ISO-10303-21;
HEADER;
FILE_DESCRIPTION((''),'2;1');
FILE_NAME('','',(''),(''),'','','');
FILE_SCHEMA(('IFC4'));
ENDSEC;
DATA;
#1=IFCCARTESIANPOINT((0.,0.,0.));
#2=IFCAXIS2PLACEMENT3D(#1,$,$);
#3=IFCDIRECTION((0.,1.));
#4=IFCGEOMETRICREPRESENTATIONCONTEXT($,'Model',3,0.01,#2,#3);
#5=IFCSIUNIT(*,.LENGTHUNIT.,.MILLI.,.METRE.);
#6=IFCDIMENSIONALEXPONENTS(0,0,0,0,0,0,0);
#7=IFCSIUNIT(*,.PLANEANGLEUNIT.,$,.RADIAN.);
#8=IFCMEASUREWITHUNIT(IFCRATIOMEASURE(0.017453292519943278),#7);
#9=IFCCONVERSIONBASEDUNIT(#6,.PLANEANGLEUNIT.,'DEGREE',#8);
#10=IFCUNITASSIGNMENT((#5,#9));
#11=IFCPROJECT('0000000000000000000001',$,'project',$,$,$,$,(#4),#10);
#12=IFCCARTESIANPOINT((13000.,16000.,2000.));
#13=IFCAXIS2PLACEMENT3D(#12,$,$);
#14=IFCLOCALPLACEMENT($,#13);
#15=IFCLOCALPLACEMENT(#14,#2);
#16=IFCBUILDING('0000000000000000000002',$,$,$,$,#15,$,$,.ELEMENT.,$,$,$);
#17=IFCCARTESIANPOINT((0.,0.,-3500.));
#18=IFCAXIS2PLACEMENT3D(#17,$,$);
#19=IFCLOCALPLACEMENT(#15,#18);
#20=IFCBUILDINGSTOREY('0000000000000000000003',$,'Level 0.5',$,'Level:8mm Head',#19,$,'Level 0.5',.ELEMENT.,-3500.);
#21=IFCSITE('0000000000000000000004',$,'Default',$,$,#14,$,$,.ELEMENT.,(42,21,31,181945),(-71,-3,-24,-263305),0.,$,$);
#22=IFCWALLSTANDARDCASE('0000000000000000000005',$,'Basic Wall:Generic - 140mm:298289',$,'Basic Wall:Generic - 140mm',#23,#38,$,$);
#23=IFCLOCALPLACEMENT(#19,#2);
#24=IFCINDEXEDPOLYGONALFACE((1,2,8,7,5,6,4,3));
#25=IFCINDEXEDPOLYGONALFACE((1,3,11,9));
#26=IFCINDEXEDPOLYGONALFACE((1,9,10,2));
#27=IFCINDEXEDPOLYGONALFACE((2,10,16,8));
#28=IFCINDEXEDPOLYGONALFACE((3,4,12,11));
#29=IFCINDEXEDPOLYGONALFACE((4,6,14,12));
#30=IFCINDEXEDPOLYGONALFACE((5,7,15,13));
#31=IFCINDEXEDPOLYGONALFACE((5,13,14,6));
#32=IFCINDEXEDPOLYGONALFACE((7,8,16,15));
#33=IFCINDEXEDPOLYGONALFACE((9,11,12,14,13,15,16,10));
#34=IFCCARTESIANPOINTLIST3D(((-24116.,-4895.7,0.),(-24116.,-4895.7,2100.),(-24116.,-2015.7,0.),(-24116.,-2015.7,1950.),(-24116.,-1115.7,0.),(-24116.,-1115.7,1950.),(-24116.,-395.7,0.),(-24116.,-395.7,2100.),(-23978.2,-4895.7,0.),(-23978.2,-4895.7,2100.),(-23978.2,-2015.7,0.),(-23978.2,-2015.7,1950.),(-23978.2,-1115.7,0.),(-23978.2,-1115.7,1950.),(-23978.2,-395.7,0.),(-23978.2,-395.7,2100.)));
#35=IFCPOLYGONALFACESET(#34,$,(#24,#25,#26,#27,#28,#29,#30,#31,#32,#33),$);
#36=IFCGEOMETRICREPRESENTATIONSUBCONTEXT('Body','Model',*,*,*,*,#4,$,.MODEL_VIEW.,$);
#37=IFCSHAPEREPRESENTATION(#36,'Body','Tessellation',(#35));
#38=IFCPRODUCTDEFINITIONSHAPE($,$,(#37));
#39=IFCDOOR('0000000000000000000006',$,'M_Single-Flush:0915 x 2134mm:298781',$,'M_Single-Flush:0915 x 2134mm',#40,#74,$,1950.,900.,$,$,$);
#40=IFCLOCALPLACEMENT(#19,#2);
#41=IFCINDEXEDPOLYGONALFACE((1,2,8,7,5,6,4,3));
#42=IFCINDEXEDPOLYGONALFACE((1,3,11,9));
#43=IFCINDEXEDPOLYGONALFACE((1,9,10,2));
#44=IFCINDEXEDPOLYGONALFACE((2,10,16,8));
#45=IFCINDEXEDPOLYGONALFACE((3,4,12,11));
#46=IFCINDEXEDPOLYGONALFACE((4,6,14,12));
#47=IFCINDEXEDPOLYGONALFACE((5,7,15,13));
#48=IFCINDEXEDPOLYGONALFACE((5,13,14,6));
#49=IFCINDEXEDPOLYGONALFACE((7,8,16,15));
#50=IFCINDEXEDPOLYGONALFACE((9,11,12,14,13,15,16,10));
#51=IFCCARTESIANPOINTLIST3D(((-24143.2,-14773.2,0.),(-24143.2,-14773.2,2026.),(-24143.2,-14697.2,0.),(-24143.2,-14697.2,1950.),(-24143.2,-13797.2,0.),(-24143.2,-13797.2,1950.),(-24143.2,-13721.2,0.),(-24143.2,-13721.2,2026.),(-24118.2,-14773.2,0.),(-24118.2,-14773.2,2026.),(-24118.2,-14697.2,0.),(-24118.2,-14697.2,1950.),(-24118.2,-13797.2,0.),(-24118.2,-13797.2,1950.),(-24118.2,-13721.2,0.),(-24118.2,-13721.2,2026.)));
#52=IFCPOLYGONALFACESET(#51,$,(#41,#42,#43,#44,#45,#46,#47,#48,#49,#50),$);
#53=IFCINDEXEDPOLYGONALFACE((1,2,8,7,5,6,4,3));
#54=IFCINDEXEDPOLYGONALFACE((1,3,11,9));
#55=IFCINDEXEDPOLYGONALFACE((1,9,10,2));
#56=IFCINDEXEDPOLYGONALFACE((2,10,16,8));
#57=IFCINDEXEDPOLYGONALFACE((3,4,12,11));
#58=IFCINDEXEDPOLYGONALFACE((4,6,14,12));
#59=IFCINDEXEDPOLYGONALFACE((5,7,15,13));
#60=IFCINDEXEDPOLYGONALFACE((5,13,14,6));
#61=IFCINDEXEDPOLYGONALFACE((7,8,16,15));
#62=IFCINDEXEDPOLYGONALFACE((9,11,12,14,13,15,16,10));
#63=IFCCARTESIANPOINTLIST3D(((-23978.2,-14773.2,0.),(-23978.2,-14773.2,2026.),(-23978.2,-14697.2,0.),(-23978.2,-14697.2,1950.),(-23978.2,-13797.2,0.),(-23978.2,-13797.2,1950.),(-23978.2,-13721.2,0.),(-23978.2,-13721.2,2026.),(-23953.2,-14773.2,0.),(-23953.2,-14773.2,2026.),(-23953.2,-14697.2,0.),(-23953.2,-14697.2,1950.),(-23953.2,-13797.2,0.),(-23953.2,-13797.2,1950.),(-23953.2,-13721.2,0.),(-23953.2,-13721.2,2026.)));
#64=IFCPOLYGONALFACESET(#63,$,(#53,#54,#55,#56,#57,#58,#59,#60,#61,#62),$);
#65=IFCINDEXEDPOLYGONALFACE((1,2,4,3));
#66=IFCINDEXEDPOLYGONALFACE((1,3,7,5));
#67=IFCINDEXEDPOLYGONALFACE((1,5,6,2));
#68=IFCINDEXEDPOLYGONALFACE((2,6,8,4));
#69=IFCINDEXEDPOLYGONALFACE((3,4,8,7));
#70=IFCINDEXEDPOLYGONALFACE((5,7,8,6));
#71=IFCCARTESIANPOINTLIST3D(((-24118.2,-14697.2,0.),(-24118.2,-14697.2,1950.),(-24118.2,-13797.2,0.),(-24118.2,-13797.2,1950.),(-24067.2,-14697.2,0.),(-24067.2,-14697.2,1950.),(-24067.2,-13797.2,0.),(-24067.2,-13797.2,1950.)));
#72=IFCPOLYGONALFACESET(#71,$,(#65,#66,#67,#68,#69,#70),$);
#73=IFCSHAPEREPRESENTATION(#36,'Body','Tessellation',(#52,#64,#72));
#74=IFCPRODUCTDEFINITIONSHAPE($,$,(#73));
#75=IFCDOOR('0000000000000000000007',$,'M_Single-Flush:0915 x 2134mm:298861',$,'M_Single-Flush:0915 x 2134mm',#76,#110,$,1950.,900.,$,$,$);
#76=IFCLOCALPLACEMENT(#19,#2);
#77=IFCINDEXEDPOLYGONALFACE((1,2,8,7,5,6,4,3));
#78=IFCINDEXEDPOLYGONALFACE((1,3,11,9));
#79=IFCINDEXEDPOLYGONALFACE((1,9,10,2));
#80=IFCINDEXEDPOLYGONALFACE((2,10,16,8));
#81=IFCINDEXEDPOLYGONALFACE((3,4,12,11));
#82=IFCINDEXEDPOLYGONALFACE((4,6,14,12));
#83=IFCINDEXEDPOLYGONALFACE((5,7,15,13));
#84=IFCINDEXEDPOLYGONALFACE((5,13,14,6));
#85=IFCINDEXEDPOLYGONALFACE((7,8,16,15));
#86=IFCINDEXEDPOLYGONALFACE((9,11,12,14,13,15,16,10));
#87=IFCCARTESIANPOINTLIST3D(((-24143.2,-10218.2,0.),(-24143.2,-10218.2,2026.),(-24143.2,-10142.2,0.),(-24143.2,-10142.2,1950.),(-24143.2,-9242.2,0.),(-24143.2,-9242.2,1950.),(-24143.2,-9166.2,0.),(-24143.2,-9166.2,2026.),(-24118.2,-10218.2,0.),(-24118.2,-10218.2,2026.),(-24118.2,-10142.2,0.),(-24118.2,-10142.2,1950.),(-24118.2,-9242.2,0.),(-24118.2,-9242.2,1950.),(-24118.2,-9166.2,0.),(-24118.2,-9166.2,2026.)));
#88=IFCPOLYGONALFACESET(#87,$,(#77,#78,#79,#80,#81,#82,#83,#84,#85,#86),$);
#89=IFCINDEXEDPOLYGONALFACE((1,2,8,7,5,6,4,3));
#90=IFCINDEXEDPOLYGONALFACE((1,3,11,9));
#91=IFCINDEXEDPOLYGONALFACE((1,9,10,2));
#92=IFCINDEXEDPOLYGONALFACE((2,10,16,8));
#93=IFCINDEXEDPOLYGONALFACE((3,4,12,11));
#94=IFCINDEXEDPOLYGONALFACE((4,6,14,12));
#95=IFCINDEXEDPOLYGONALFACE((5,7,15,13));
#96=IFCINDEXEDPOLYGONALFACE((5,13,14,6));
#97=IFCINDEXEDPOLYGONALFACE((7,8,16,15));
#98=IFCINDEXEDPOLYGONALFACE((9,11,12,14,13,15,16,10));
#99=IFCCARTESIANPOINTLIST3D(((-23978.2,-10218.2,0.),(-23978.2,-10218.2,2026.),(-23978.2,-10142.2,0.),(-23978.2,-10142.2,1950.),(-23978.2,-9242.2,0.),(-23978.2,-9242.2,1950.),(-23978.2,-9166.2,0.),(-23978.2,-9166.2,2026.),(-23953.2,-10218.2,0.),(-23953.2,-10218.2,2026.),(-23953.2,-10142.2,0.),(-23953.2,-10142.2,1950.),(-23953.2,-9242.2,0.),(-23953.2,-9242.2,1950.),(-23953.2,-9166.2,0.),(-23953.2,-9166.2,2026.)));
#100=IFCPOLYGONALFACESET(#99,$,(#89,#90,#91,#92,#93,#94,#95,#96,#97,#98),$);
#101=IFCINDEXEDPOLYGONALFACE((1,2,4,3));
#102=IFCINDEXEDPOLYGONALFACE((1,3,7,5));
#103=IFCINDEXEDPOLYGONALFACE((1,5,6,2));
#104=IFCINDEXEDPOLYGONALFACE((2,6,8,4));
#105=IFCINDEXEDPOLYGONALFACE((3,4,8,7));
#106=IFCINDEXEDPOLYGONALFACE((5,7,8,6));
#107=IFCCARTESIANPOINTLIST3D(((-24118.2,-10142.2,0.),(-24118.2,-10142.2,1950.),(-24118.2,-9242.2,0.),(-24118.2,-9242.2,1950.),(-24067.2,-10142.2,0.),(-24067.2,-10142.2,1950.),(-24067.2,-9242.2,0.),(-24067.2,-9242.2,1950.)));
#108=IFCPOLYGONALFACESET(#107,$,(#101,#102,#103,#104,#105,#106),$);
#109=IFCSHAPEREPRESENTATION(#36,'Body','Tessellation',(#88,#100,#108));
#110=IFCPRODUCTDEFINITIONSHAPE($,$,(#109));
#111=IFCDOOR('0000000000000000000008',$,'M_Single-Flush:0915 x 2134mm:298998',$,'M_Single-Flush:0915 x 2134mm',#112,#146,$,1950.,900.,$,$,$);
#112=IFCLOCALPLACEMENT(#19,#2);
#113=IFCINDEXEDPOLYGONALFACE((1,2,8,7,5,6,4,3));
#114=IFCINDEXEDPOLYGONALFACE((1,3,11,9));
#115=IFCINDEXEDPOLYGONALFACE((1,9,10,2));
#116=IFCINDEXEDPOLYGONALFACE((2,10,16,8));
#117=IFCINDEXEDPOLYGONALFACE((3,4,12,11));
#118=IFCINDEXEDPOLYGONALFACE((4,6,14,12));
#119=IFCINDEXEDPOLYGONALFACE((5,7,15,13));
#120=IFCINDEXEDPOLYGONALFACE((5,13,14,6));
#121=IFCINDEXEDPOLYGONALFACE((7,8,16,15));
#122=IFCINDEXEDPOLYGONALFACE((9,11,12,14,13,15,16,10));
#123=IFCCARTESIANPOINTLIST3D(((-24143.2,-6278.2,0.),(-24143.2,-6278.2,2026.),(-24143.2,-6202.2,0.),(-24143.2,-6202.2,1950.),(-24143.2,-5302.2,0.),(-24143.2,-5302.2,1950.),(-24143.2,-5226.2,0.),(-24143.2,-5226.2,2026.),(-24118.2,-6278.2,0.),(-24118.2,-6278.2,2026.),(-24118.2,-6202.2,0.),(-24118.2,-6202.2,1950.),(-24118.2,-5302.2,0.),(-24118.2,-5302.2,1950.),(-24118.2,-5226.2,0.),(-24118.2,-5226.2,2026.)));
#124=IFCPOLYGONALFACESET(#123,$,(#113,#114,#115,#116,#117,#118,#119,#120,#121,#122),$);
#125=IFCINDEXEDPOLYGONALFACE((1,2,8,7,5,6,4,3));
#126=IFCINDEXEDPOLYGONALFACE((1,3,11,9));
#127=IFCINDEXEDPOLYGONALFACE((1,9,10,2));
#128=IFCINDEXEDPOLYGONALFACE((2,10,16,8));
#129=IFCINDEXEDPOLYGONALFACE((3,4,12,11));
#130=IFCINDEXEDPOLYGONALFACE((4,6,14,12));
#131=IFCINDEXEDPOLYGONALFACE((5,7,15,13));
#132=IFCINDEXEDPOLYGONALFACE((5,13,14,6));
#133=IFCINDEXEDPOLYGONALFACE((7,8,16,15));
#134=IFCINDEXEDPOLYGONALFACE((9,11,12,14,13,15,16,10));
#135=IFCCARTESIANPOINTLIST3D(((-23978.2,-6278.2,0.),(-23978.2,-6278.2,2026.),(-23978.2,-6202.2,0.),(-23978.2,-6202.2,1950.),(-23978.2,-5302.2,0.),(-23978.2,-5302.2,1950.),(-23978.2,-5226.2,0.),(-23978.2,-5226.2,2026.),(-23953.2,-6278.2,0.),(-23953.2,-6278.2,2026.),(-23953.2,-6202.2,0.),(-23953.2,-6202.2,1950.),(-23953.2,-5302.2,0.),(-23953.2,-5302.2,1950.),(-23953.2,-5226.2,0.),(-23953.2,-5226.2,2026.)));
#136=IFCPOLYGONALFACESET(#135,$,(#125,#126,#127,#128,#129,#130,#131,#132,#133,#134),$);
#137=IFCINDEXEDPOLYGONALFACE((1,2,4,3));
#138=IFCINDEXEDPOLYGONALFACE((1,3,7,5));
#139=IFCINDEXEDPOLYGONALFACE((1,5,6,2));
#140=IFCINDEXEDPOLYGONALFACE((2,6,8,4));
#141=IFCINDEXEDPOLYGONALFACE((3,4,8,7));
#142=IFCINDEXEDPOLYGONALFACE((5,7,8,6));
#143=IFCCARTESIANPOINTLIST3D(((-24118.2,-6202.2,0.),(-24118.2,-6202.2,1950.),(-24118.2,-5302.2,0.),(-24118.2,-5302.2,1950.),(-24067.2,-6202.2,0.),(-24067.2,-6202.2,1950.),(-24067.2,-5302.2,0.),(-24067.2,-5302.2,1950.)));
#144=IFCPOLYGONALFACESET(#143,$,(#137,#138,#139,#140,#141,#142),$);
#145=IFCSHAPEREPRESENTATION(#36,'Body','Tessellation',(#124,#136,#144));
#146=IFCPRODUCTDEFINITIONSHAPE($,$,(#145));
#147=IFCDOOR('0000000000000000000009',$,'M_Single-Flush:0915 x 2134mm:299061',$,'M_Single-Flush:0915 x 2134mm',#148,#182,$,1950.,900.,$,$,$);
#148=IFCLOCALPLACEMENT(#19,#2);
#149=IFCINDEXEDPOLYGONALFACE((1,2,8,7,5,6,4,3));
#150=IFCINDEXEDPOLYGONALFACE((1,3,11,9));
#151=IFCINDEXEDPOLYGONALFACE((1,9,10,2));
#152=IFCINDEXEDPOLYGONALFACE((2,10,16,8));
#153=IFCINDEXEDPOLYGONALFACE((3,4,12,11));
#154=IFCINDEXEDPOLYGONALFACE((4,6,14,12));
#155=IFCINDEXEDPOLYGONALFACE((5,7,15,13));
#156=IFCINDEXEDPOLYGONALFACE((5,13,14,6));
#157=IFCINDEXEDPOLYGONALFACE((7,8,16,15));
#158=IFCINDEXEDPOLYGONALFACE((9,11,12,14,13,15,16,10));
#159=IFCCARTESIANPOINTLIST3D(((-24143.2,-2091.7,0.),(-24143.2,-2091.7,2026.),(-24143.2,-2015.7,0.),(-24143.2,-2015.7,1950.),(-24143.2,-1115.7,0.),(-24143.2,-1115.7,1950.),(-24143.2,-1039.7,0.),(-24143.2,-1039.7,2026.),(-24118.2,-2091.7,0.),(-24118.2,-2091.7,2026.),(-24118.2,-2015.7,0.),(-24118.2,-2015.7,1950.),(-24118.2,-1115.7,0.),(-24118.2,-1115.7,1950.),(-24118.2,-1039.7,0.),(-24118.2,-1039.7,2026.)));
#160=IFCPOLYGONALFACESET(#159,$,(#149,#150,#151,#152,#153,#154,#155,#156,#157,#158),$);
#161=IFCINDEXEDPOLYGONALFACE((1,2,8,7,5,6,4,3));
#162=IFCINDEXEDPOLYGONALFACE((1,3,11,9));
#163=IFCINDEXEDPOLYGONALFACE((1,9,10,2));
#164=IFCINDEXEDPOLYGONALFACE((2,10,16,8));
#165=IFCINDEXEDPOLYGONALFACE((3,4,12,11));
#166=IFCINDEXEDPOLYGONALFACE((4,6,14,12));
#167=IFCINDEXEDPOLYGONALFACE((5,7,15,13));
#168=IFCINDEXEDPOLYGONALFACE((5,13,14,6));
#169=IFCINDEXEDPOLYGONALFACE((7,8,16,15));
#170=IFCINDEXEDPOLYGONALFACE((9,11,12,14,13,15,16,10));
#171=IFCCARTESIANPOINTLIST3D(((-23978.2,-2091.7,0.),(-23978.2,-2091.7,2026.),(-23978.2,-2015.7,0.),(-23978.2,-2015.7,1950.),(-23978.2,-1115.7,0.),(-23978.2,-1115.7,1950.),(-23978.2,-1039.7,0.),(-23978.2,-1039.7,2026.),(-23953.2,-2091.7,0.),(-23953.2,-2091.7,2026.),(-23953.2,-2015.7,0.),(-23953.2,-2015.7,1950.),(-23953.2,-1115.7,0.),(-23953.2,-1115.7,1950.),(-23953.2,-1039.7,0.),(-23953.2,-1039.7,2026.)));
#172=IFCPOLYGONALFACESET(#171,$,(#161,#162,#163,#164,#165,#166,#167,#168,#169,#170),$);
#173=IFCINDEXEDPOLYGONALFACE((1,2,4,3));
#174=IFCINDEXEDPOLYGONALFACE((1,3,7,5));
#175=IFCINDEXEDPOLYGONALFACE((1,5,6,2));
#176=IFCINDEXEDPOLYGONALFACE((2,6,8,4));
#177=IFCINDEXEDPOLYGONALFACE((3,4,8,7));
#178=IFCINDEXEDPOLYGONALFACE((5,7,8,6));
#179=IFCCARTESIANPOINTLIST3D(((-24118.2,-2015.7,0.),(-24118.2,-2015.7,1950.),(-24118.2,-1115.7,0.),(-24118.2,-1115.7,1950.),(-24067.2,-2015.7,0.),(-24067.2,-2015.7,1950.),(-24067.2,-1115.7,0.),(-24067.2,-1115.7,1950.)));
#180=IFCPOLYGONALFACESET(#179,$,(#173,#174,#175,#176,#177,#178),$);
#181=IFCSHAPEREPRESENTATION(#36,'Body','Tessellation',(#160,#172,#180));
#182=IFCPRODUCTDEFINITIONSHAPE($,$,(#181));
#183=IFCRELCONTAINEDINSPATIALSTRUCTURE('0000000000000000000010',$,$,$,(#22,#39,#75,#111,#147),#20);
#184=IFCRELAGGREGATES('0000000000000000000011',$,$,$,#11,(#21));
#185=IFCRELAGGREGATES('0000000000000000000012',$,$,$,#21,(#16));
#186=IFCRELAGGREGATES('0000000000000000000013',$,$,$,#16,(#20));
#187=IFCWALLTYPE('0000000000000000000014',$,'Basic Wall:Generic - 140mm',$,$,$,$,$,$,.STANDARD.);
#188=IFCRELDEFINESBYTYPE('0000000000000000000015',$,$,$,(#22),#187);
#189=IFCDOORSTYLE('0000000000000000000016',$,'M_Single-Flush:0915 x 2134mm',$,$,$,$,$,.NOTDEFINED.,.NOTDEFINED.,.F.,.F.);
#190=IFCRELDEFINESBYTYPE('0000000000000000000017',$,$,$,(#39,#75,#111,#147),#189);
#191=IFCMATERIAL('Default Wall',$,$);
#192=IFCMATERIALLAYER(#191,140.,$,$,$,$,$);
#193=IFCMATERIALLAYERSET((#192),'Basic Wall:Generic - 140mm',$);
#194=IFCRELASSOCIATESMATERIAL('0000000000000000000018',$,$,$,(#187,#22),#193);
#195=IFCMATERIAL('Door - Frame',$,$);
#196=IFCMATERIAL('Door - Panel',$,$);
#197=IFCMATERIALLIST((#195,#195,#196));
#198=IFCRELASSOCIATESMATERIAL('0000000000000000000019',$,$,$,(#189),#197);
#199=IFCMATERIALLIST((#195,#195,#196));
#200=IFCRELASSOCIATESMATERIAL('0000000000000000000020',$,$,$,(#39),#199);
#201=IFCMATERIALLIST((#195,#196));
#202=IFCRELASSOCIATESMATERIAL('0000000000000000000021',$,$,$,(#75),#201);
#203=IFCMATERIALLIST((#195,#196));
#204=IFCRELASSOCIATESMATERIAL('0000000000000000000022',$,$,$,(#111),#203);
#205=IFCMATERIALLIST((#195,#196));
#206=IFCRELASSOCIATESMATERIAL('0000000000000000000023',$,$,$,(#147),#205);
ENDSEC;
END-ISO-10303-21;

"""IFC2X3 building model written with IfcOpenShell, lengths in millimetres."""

from ifc_helpers import new_model, entity, si_unit, converted_unit, direction, frame, frame_2d, origin, place, context, subcontext, project, spatial, polyline, rectangle, outline, extrude, clip, bounded_halfspace, source, transform, mapped, material, material_list, layer, layer_set, layer_usage, type_object, type_shapes, element, fill, save


model = new_model("IFC2X3")

# Units and contexts
model_context = context("Model", 3, precision=0.01, world=origin(), true_north=direction((0.0, 1.0)))
body_context = subcontext(model_context, "Body", "Model", "MODEL_VIEW")
ifc_project = project(units=[si_unit("LENGTHUNIT", "METRE", prefix="MILLI"), converted_unit("PLANEANGLEUNIT", "DEGREE", entity("IfcRatioMeasure", 0.017453292519943278), si_unit("PLANEANGLEUNIT", "RADIAN"), dimensions=[0, 0, 0, 0, 0, 0, 0])], contexts=[model_context])

# Site, building, storey
site_placement = place(None, frame((13000.0, 16000.0, 2000.0)))
site = spatial("IfcSite", under=ifc_project, at=site_placement, Name="Default", CompositionType="ELEMENT", RefLatitude=(42, 21, 31, 181945), RefLongitude=(-71, -3, -24, -263305), RefElevation=0.0)
building_placement = place(site_placement, origin())
building = spatial("IfcBuilding", under=site, at=building_placement, CompositionType="ELEMENT")
storey_placement = place(building_placement, frame((0.0, 0.0, -3500.0)))
storey = spatial("IfcBuildingStorey", under=building, at=storey_placement, Name="Level 0.5", ObjectType="Level:8mm Head", LongName="Level 0.5", CompositionType="ELEMENT", Elevation=-3500.0)

# Shared definitions
ifc_material_1 = material(Name="Default Wall")

# Shared definitions
ifc_material_2 = material(Name="Door - Frame")
ifc_material_3 = material(Name="Door - Panel")

# Wall, openings, doors
ifc_layer_1 = layer(ifc_material_1, 140.0)
ifc_layer_set_1 = layer_set([ifc_layer_1], Name="Basic Wall:Generic - 140mm")
ifc_layer_usage_1 = layer_usage(ifc_layer_set_1, "AXIS2", "NEGATIVE", 70.0)
wall_type_1 = type_object("IfcWallType", Name="Basic Wall:Generic - 140mm", PredefinedType="STANDARD", material=ifc_layer_set_1)
wall_1_placement = place(storey_placement, frame((-24048.2, -395.7, 0.0), z_axis=(0.0, 0.0, 1.0), x_axis=(0.0, -1.0, 0.0)))
wall_1 = element("IfcWallStandardCase", 1, at=wall_1_placement, inside=storey, type_object=wall_type_1, material=ifc_layer_usage_1, Name="Basic Wall:Generic - 140mm:298289", ObjectType="Basic Wall:Generic - 140mm", context=body_context, shape_type="Clipping", body=[
    clip(extrude(rectangle(XDim=137.7, YDim=4500.0, at=frame_2d((2250.0, 1.1), x_axis=(0.0, 1.0))), origin(), (0.0, 0.0, 1.0), 2100.0), bounded_halfspace(frame((4500.0, -67.7, 2100.0), z_axis=(0.0, 0.0, -1.0), x_axis=(0.0, -1.0, 0.0)), True, frame((4500.0, -67.7, 2100.0)), polyline([(0.0, 0.0), (0.0, 41986.2), (-1371600.0, 41986.2), (-1371600.0, 0.0), (0.0, 0.0)]))),
])
opening_1_placement = place(wall_1_placement, frame((14301.5, 70.0, 0.0)))
opening_1 = element("IfcOpeningElement", 2, at=opening_1_placement, cuts=wall_1, ObjectType="Opening", context=body_context, shape_type="SweptSolid", body=[
    extrude(rectangle(XDim=900.0, YDim=1950.0, at=frame_2d((975.0, 450.0), x_axis=(0.0, -1.0))), frame((0.0, 0.0, 0.0), z_axis=(0.0, -1.0, 0.0), x_axis=(0.0, 0.0, 1.0)), (0.0, 0.0, 1.0), 140.0),
])
opening_2_placement = place(wall_1_placement, frame((9746.5, 70.0, 0.0)))
opening_2 = element("IfcOpeningElement", 3, at=opening_2_placement, cuts=wall_1, ObjectType="Opening", context=body_context, shape_type="SweptSolid", body=[
    extrude(rectangle(XDim=900.0, YDim=1950.0, at=frame_2d((975.0, 450.0), x_axis=(0.0, -1.0))), frame((0.0, 0.0, 0.0), z_axis=(0.0, -1.0, 0.0), x_axis=(0.0, 0.0, 1.0)), (0.0, 0.0, 1.0), 140.0),
])
opening_3_placement = place(wall_1_placement, frame((5806.5, 70.0, 0.0)))
opening_3 = element("IfcOpeningElement", 4, at=opening_3_placement, cuts=wall_1, ObjectType="Opening", context=body_context, shape_type="SweptSolid", body=[
    extrude(rectangle(XDim=900.0, YDim=1950.0, at=frame_2d((975.0, 450.0), x_axis=(0.0, -1.0))), frame((0.0, 0.0, 0.0), z_axis=(0.0, -1.0, 0.0), x_axis=(0.0, 0.0, 1.0)), (0.0, 0.0, 1.0), 140.0),
])
opening_4_placement = place(wall_1_placement, frame((1620.0, 70.0, 0.0)))
opening_4 = element("IfcOpeningElement", 5, at=opening_4_placement, cuts=wall_1, ObjectType="Opening", context=body_context, shape_type="SweptSolid", body=[
    extrude(rectangle(XDim=900.0, YDim=1950.0, at=frame_2d((975.0, 450.0), x_axis=(0.0, -1.0))), frame((0.0, 0.0, 0.0), z_axis=(0.0, -1.0, 0.0), x_axis=(0.0, 0.0, 1.0)), (0.0, 0.0, 1.0), 140.0),
])
ifc_material_list_1 = material_list([ifc_material_2, ifc_material_2, ifc_material_3])
ifc_material_list_2 = material_list([ifc_material_2, ifc_material_2, ifc_material_3])
door_style_1 = type_object("IfcDoorStyle", Name="M_Single-Flush:0915 x 2134mm", ConstructionType="NOTDEFINED", OperationType="NOTDEFINED", ParameterTakesPrecedence=False, Sizeable=False, material=ifc_material_list_2)
shared_shape_1 = source(origin(), body_context, "Body", "SweptSolid", [
    extrude(outline(polyline([(-526.0, -1032.0), (526.0, -1032.0), (526.0, 994.0), (450.0, 994.0), (450.0, -956.0), (-450.0, -956.0), (-450.0, 994.0), (-526.0, 994.0), (-526.0, -1032.0)])), frame((450.0, 165.0, 994.0), z_axis=(0.0, -1.0, 0.0), x_axis=(-1.0, 0.0, 0.0)), (0.0, 0.0, 1.0), 25.0),
    extrude(outline(polyline([(-1032.0, -526.0), (994.0, -526.0), (994.0, -450.0), (-956.0, -450.0), (-956.0, 450.0), (994.0, 450.0), (994.0, 526.0), (-1032.0, 526.0), (-1032.0, -526.0)])), frame((450.0, 0.0, 994.0), z_axis=(0.0, -1.0, 0.0), x_axis=(0.0, 0.0, -1.0)), (0.0, 0.0, 1.0), 25.0),
    extrude(rectangle(XDim=900.0, YDim=51.0, at=frame_2d((0.0, 0.0), x_axis=(1.0, 0.0))), frame((450.0, 114.5, 0.0)), (0.0, 0.0, 1.0), 1950.0),
])
type_shapes(door_style_1, [shared_shape_1])
door_1_placement = place(opening_1_placement, frame((0.0, 0.0, 0.0), z_axis=(0.0, 0.0, 1.0), x_axis=(-1.0, 0.0, 0.0)))
door_1 = element("IfcDoor", 6, at=door_1_placement, inside=storey, type_object=door_style_1, material=ifc_material_list_1, Name="M_Single-Flush:0915 x 2134mm:298781", ObjectType="M_Single-Flush:0915 x 2134mm", OverallHeight=1950.0, OverallWidth=900.0, context=body_context, shape_type="MappedRepresentation", body=[
    mapped(shared_shape_1, transform((0.0, 0.0, 0.0), scale=1.0)),
])
fill(opening_1, door_1)
ifc_material_list_3 = material_list([ifc_material_2, ifc_material_3])
door_2_placement = place(opening_2_placement, frame((0.0, 0.0, 0.0), z_axis=(0.0, 0.0, 1.0), x_axis=(-1.0, 0.0, 0.0)))
door_2 = element("IfcDoor", 7, at=door_2_placement, inside=storey, type_object=door_style_1, material=ifc_material_list_3, Name="M_Single-Flush:0915 x 2134mm:298861", ObjectType="M_Single-Flush:0915 x 2134mm", OverallHeight=1950.0, OverallWidth=900.0, context=body_context, shape_type="MappedRepresentation", body=[
    mapped(shared_shape_1, transform((0.0, 0.0, 0.0), scale=1.0)),
])
fill(opening_2, door_2)
ifc_material_list_4 = material_list([ifc_material_2, ifc_material_3])
door_3_placement = place(opening_3_placement, frame((0.0, 0.0, 0.0), z_axis=(0.0, 0.0, 1.0), x_axis=(-1.0, 0.0, 0.0)))
door_3 = element("IfcDoor", 8, at=door_3_placement, inside=storey, type_object=door_style_1, material=ifc_material_list_4, Name="M_Single-Flush:0915 x 2134mm:298998", ObjectType="M_Single-Flush:0915 x 2134mm", OverallHeight=1950.0, OverallWidth=900.0, context=body_context, shape_type="MappedRepresentation", body=[
    mapped(shared_shape_1, transform((0.0, 0.0, 0.0), scale=1.0)),
])
fill(opening_3, door_3)
ifc_material_list_5 = material_list([ifc_material_2, ifc_material_3])
door_4_placement = place(opening_4_placement, frame((0.0, 0.0, 0.0), z_axis=(0.0, 0.0, 1.0), x_axis=(-1.0, 0.0, 0.0)))
door_4 = element("IfcDoor", 9, at=door_4_placement, inside=storey, type_object=door_style_1, material=ifc_material_list_5, Name="M_Single-Flush:0915 x 2134mm:299061", ObjectType="M_Single-Flush:0915 x 2134mm", OverallHeight=1950.0, OverallWidth=900.0, context=body_context, shape_type="MappedRepresentation", body=[
    mapped(shared_shape_1, transform((0.0, 0.0, 0.0), scale=1.0)),
])
fill(opening_4, door_4)

save(model, "model.ifc")
